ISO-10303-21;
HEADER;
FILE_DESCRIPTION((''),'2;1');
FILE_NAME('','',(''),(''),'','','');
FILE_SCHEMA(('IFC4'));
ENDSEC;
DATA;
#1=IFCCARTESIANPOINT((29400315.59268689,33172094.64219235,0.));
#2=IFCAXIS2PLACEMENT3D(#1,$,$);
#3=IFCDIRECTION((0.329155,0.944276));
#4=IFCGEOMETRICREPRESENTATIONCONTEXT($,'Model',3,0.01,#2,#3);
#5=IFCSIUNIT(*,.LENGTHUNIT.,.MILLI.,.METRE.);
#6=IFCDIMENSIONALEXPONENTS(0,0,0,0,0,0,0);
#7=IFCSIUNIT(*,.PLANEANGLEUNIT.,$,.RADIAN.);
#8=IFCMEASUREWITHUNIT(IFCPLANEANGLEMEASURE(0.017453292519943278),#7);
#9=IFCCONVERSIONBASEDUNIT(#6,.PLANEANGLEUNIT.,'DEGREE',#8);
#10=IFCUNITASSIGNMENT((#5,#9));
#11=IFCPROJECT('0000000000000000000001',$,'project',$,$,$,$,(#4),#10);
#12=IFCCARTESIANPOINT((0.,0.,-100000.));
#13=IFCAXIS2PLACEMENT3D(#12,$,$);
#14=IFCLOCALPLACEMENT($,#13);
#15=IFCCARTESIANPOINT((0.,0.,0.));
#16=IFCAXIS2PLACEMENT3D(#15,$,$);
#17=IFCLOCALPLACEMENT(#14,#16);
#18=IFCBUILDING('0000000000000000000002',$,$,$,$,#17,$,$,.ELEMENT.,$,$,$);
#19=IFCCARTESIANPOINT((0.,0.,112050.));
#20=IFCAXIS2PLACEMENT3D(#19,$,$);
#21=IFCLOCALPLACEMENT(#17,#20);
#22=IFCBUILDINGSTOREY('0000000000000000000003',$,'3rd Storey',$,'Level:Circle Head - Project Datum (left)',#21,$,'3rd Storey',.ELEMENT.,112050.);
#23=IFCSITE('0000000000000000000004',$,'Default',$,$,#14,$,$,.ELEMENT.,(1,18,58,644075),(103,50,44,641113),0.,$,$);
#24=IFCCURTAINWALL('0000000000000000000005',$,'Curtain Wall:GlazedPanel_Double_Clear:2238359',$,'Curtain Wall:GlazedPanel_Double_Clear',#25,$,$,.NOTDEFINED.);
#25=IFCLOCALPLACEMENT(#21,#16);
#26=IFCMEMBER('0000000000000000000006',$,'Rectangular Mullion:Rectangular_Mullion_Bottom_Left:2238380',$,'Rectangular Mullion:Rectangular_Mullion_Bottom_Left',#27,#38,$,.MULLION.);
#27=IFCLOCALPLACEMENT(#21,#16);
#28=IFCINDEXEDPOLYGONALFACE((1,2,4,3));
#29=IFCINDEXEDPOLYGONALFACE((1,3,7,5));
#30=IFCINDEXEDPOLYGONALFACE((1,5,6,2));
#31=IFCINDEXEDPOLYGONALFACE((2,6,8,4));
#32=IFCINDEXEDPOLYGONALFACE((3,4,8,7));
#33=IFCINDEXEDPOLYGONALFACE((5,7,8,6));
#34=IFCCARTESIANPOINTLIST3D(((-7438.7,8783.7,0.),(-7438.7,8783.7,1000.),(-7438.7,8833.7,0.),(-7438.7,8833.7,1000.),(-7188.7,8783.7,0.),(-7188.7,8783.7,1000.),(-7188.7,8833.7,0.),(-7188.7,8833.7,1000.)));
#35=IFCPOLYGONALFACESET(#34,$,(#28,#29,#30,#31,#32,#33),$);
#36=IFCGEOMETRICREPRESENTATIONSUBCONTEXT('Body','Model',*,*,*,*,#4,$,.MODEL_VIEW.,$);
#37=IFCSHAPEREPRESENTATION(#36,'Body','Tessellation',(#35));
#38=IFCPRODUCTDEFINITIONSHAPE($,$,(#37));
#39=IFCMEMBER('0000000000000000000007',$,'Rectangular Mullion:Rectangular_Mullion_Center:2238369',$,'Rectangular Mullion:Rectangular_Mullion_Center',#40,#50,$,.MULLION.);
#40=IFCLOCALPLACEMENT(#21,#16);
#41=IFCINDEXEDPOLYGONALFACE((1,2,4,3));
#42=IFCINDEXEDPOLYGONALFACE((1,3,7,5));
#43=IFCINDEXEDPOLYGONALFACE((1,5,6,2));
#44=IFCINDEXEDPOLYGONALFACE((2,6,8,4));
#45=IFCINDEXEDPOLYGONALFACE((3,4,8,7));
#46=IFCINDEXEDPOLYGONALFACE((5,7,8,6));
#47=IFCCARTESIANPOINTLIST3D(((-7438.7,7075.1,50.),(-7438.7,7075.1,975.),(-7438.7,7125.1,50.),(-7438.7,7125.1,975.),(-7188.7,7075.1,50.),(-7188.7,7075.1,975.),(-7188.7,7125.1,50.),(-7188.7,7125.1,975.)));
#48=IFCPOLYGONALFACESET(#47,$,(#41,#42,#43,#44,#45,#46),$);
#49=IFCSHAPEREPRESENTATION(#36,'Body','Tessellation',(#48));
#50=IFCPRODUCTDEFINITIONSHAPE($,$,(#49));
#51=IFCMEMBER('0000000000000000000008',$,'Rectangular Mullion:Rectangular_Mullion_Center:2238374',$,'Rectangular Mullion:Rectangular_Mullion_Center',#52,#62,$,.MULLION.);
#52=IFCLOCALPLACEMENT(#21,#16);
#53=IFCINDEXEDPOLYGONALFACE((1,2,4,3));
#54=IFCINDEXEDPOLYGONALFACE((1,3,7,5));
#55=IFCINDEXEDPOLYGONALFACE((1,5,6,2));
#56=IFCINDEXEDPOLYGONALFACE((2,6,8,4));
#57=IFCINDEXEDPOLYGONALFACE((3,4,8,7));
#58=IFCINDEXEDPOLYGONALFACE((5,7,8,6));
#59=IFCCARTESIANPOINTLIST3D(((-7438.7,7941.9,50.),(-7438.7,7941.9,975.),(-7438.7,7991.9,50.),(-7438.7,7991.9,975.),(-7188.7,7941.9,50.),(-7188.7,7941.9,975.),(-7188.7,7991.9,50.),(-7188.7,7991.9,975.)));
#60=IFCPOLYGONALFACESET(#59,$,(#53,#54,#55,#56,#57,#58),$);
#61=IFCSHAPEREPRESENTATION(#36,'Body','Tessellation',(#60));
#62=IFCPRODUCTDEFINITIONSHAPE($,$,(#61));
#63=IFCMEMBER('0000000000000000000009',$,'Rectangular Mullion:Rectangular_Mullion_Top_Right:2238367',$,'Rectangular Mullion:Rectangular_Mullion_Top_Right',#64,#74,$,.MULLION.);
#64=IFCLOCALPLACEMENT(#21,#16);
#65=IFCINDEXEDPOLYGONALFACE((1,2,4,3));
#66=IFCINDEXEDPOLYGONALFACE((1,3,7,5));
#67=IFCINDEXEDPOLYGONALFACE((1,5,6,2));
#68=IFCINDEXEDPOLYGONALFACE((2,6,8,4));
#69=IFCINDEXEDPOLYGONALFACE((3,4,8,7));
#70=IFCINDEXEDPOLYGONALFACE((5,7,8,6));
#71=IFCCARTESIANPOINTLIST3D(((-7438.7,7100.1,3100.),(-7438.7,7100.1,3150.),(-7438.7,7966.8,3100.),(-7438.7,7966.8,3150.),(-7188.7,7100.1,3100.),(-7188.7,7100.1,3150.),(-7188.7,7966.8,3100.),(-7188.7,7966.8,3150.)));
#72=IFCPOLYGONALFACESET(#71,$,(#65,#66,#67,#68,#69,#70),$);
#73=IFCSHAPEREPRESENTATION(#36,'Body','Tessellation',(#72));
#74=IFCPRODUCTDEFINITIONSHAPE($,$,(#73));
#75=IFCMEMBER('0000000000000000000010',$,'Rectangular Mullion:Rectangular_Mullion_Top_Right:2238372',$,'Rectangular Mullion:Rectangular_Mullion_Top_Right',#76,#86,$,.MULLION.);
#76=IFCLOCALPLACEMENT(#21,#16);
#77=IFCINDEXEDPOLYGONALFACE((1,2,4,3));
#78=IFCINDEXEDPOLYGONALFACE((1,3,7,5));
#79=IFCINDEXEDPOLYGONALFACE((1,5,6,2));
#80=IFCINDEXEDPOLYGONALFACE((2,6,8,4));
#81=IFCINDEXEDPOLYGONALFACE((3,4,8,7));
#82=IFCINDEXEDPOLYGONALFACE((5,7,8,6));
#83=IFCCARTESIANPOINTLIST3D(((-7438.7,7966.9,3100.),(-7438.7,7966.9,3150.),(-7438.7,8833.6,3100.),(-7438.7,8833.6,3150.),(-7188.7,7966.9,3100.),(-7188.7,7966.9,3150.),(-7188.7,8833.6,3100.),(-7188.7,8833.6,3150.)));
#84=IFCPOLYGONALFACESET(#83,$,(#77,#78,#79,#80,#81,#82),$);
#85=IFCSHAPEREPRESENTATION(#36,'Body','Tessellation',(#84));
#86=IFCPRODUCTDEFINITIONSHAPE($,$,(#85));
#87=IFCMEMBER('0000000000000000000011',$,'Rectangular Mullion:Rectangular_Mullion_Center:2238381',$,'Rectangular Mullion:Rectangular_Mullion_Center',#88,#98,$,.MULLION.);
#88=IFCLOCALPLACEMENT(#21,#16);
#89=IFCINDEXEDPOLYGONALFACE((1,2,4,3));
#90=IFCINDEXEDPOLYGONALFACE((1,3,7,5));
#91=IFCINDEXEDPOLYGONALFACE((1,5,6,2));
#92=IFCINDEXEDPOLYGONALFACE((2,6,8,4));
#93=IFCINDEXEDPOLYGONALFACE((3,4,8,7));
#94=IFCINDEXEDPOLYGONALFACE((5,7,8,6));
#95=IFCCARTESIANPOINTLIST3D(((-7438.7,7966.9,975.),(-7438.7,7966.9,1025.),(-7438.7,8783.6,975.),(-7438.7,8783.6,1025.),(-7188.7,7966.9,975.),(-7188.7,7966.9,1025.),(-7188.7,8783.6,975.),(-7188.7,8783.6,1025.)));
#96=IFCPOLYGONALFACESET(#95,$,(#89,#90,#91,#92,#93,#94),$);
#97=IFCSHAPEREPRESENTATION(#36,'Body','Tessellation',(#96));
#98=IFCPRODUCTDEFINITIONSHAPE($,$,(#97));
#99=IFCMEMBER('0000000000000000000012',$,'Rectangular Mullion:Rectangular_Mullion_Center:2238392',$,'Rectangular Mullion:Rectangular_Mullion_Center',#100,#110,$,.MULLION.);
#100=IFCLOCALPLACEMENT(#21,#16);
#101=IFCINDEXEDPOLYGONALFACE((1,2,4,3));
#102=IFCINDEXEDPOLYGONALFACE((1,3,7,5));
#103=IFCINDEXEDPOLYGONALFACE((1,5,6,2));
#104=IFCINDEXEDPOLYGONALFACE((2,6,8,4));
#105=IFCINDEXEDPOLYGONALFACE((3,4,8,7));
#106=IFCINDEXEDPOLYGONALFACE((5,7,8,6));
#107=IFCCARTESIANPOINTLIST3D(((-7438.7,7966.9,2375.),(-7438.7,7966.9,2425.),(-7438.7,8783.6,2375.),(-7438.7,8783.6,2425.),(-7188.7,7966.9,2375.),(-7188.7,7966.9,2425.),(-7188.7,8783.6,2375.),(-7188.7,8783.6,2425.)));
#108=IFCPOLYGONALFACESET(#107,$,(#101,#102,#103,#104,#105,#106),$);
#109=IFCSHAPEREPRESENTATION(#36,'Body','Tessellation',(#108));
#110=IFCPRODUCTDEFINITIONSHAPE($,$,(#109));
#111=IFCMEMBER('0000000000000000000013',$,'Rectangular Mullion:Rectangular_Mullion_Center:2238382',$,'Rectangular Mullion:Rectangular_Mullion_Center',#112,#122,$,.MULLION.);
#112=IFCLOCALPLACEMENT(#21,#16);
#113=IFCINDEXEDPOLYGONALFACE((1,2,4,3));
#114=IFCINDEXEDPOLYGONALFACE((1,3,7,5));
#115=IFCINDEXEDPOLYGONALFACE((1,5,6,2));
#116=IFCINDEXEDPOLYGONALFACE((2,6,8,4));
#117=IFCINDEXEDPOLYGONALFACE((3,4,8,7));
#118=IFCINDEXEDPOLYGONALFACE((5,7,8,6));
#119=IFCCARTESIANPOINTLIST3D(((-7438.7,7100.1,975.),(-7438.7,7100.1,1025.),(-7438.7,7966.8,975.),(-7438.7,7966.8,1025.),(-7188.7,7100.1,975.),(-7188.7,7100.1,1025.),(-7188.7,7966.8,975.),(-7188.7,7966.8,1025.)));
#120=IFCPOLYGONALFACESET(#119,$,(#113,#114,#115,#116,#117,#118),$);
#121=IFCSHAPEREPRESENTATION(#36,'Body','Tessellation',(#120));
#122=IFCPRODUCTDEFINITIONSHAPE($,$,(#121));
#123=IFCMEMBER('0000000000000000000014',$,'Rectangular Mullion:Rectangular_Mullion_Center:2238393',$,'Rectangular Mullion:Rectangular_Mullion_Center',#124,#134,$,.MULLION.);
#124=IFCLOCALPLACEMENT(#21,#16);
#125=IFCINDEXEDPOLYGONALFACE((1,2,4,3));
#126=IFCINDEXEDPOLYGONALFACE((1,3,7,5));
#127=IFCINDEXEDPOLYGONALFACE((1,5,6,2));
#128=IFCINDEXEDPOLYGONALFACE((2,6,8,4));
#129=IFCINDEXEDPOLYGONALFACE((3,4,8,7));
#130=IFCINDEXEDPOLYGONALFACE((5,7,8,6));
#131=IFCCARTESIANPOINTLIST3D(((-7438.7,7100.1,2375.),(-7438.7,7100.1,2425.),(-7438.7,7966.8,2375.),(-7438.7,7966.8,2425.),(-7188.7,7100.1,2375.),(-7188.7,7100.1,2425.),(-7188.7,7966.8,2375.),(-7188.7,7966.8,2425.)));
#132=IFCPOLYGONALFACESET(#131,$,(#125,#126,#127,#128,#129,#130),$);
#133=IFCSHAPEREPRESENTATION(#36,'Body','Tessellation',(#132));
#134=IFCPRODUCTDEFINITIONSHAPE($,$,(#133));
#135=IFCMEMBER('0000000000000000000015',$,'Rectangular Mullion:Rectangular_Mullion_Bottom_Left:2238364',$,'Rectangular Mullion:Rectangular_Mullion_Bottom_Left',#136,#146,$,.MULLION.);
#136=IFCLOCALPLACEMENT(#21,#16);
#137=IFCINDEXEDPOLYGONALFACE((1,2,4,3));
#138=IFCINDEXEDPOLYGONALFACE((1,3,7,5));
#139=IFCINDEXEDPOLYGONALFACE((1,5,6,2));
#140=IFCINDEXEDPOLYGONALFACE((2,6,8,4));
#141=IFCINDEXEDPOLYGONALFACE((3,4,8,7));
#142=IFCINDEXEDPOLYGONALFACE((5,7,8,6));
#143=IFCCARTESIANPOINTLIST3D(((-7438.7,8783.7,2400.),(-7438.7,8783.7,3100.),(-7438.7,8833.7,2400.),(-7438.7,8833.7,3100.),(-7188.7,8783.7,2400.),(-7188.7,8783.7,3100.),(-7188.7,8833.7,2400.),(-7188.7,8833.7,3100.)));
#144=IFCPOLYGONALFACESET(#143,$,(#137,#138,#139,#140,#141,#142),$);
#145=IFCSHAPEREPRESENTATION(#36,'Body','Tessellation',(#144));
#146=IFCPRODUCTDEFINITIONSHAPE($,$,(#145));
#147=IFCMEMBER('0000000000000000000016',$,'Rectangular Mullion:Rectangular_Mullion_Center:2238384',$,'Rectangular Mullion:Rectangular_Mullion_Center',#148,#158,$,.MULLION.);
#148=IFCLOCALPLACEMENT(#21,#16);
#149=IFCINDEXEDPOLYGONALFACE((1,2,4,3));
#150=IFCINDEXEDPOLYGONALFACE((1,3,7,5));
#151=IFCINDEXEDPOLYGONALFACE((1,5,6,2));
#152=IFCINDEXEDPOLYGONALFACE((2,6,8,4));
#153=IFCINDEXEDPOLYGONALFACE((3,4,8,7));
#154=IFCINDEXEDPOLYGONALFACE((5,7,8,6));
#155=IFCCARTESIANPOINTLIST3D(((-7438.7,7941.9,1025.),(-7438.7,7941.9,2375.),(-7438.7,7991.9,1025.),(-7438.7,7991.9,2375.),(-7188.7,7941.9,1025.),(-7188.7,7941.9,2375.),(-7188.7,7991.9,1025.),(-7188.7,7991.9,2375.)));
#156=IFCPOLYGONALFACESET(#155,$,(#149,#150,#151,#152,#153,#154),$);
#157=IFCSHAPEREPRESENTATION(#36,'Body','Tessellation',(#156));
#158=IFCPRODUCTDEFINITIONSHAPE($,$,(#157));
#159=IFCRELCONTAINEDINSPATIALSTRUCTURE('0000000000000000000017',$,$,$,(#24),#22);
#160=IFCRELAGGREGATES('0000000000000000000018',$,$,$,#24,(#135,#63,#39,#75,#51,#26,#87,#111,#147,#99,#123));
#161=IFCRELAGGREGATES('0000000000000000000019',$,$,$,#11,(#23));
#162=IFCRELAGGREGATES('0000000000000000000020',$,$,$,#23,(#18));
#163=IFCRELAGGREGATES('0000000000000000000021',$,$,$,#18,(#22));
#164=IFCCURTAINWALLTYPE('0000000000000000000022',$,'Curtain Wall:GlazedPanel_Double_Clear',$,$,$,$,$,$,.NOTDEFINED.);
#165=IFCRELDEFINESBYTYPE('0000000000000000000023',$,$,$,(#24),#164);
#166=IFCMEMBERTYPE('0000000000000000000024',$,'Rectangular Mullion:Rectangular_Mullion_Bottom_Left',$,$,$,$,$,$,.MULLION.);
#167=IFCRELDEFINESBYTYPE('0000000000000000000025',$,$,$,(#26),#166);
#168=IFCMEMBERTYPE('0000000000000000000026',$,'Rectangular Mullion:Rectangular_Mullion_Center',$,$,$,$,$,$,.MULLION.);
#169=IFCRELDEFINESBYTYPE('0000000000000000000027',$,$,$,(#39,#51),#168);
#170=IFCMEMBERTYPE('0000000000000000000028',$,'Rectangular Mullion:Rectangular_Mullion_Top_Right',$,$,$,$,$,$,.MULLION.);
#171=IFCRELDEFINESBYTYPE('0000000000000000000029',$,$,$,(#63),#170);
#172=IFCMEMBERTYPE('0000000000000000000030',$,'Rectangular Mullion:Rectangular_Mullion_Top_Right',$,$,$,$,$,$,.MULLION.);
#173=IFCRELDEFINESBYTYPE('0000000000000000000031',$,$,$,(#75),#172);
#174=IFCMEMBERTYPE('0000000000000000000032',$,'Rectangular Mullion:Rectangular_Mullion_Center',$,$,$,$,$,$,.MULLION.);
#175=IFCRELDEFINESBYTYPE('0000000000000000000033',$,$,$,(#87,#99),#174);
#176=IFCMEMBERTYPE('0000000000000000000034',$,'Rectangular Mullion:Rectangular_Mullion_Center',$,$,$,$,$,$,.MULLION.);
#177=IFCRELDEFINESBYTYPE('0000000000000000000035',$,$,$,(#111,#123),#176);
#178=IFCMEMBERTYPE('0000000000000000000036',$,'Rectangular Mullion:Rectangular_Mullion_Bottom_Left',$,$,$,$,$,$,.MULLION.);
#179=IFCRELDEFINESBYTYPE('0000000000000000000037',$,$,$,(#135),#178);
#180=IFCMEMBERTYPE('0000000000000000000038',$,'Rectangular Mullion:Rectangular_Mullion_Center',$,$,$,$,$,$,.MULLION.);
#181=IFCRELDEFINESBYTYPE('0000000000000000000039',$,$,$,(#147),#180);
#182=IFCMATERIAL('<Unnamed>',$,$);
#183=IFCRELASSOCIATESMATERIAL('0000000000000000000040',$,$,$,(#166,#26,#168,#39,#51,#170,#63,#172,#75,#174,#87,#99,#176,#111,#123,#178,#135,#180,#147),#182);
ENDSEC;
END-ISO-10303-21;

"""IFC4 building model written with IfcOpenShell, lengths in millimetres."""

from ifc_helpers import new_model, entity, si_unit, converted_unit, direction, frame, origin, place, context, subcontext, project, spatial, indexed_curve, outline, extrude, source, transform, mapped, material, type_object, type_shapes, element, aggregate, save


model = new_model("IFC4")

# Units and contexts
model_context = context("Model", 3, precision=0.01, world=frame((29400315.59268689, 33172094.64219235, 0.0)), true_north=direction((0.329155, 0.944276)))
body_context = subcontext(model_context, "Body", "Model", "MODEL_VIEW")
ifc_project = project(units=[si_unit("LENGTHUNIT", "METRE", prefix="MILLI"), converted_unit("PLANEANGLEUNIT", "DEGREE", entity("IfcPlaneAngleMeasure", 0.017453292519943278), si_unit("PLANEANGLEUNIT", "RADIAN"), dimensions=[0, 0, 0, 0, 0, 0, 0])], contexts=[model_context])

# Site, building, storey
site_placement = place(None, frame((0.0, 0.0, -100000.0)))
site = spatial("IfcSite", under=ifc_project, at=site_placement, Name="Default", CompositionType="ELEMENT", RefLatitude=(1, 18, 58, 644075), RefLongitude=(103, 50, 44, 641113), RefElevation=0.0)
building_placement = place(site_placement, origin())
building = spatial("IfcBuilding", under=site, at=building_placement, CompositionType="ELEMENT")
storey_placement = place(building_placement, frame((0.0, 0.0, 112050.0)))
storey = spatial("IfcBuildingStorey", under=building, at=storey_placement, Name="3rd Storey", ObjectType="Level:Circle Head - Project Datum (left)", LongName="3rd Storey", CompositionType="ELEMENT", Elevation=112050.0)

# Curtain wall, members
curtain_wall_type = type_object("IfcCurtainWallType", Name="Curtain Wall:GlazedPanel_Double_Clear", PredefinedType="NOTDEFINED")
curtain_wall_1_placement = place(storey_placement, frame((0.0, 0.0, -112050.0)))
curtain_wall_1 = element("IfcCurtainWall", 1, at=curtain_wall_1_placement, inside=storey, type_object=curtain_wall_type, Name="Curtain Wall:GlazedPanel_Double_Clear:2238359", ObjectType="Curtain Wall:GlazedPanel_Double_Clear", PredefinedType="NOTDEFINED")
ifc_material_1 = material(Name="<Unnamed>")
member_type_1 = type_object("IfcMemberType", Name="Rectangular Mullion:Rectangular_Mullion_Bottom_Left", PredefinedType="MULLION", material=ifc_material_1)
shared_shape_1 = source(origin(), body_context, "Body", "SweptSolid", [
    extrude(outline(indexed_curve([(-25.0, -125.0), (25.0, -125.0), (25.0, 125.0), (-25.0, 125.0), (-25.0, -125.0)], self_intersect=False)), frame((-25.0, 0.0, -1000.0), z_axis=(0.0, 0.0, 1.0), x_axis=(-1.0, 0.0, 0.0)), (0.0, 0.0, 1.0), 1000.0),
])
type_shapes(member_type_1, [shared_shape_1])
member_1_placement = place(curtain_wall_1_placement, frame((-7313.7, 8833.7, 113050.0), z_axis=(0.0, 0.0, 1.0), x_axis=(0.0, 1.0, 0.0)))
member_1 = element("IfcMember", 2, at=member_1_placement, type_object=member_type_1, material=ifc_material_1, Name="Rectangular Mullion:Rectangular_Mullion_Bottom_Left:2238380", ObjectType="Rectangular Mullion:Rectangular_Mullion_Bottom_Left", PredefinedType="MULLION", context=body_context, shape_type="MappedRepresentation", body=[
    mapped(shared_shape_1, transform((0.0, 0.0, 0.0), scale=1.0)),
])
member_type_2 = type_object("IfcMemberType", Name="Rectangular Mullion:Rectangular_Mullion_Center", PredefinedType="MULLION", material=ifc_material_1)
shared_shape_2 = source(origin(), body_context, "Body", "SweptSolid", [
    extrude(outline(indexed_curve([(-25.0, -125.0), (25.0, -125.0), (25.0, 125.0), (-25.0, 125.0), (-25.0, -125.0)], self_intersect=False)), frame((0.0, 0.0, -925.0), z_axis=(0.0, 0.0, 1.0), x_axis=(-1.0, 0.0, 0.0)), (0.0, 0.0, 1.0), 925.0),
])
type_shapes(member_type_2, [shared_shape_2])
member_2_placement = place(curtain_wall_1_placement, frame((-7313.7, 7100.1, 112100.0), z_axis=(0.0, 0.0, -1.0), x_axis=(0.0, -1.0, 0.0)))
member_2 = element("IfcMember", 3, at=member_2_placement, type_object=member_type_2, material=ifc_material_1, Name="Rectangular Mullion:Rectangular_Mullion_Center:2238369", ObjectType="Rectangular Mullion:Rectangular_Mullion_Center", PredefinedType="MULLION", context=body_context, shape_type="MappedRepresentation", body=[
    mapped(shared_shape_2, transform((0.0, 0.0, 0.0), scale=1.0)),
])
member_3_placement = place(curtain_wall_1_placement, frame((-7313.7, 7966.9, 112100.0), z_axis=(0.0, 0.0, -1.0), x_axis=(0.0, -1.0, 0.0)))
member_3 = element("IfcMember", 4, at=member_3_placement, type_object=member_type_2, material=ifc_material_1, Name="Rectangular Mullion:Rectangular_Mullion_Center:2238374", ObjectType="Rectangular Mullion:Rectangular_Mullion_Center", PredefinedType="MULLION", context=body_context, shape_type="MappedRepresentation", body=[
    mapped(shared_shape_2, transform((0.0, 0.0, 0.0), scale=1.0)),
])
member_type_3 = type_object("IfcMemberType", Name="Rectangular Mullion:Rectangular_Mullion_Top_Right", PredefinedType="MULLION", material=ifc_material_1)
shared_shape_3 = source(origin(), body_context, "Body", "SweptSolid", [
    extrude(outline(indexed_curve([(-25.0, -125.0), (25.0, -125.0), (25.0, 125.0), (-25.0, 125.0), (-25.0, -125.0)], self_intersect=False)), frame((-25.0, 0.0, -866.7), z_axis=(0.0, 0.0, 1.0), x_axis=(-1.0, 0.0, 0.0)), (0.0, 0.0, 1.0), 866.7),
])
type_shapes(member_type_3, [shared_shape_3])
member_4_placement = place(curtain_wall_1_placement, frame((-7313.7, 7100.1, 115200.0), z_axis=(0.0, -1.0, 0.0), x_axis=(0.0, 0.0, 1.0)))
member_4 = element("IfcMember", 5, at=member_4_placement, type_object=member_type_3, material=ifc_material_1, Name="Rectangular Mullion:Rectangular_Mullion_Top_Right:2238367", ObjectType="Rectangular Mullion:Rectangular_Mullion_Top_Right", PredefinedType="MULLION", context=body_context, shape_type="MappedRepresentation", body=[
    mapped(shared_shape_3, transform((0.0, 0.0, 0.0), scale=1.0)),
])
member_type_4 = type_object("IfcMemberType", Name="Rectangular Mullion:Rectangular_Mullion_Top_Right", PredefinedType="MULLION", material=ifc_material_1)
shared_shape_4 = source(origin(), body_context, "Body", "SweptSolid", [
    extrude(outline(indexed_curve([(-25.0, -125.0), (25.0, -125.0), (25.0, 125.0), (-25.0, 125.0), (-25.0, -125.0)], self_intersect=False)), frame((-25.0, 0.0, -866.7), z_axis=(0.0, 0.0, 1.0), x_axis=(-1.0, 0.0, 0.0)), (0.0, 0.0, 1.0), 866.7),
])
type_shapes(member_type_4, [shared_shape_4])
member_5_placement = place(curtain_wall_1_placement, frame((-7313.7, 7966.9, 115200.0), z_axis=(0.0, -1.0, 0.0), x_axis=(0.0, 0.0, 1.0)))
member_5 = element("IfcMember", 6, at=member_5_placement, type_object=member_type_4, material=ifc_material_1, Name="Rectangular Mullion:Rectangular_Mullion_Top_Right:2238372", ObjectType="Rectangular Mullion:Rectangular_Mullion_Top_Right", PredefinedType="MULLION", context=body_context, shape_type="MappedRepresentation", body=[
    mapped(shared_shape_4, transform((0.0, 0.0, 0.0), scale=1.0)),
])
member_type_5 = type_object("IfcMemberType", Name="Rectangular Mullion:Rectangular_Mullion_Center", PredefinedType="MULLION", material=ifc_material_1)
shared_shape_5 = source(origin(), body_context, "Body", "SweptSolid", [
    extrude(outline(indexed_curve([(-25.0, -125.0), (25.0, -125.0), (25.0, 125.0), (-25.0, 125.0), (-25.0, -125.0)], self_intersect=False)), frame((0.0, 0.0, -816.7), z_axis=(0.0, 0.0, 1.0), x_axis=(-1.0, 0.0, 0.0)), (0.0, 0.0, 1.0), 816.7),
])
type_shapes(member_type_5, [shared_shape_5])
member_6_placement = place(curtain_wall_1_placement, frame((-7313.7, 7966.9, 113050.0), z_axis=(0.0, -1.0, 0.0), x_axis=(0.0, 0.0, 1.0)))
member_6 = element("IfcMember", 7, at=member_6_placement, type_object=member_type_5, material=ifc_material_1, Name="Rectangular Mullion:Rectangular_Mullion_Center:2238381", ObjectType="Rectangular Mullion:Rectangular_Mullion_Center", PredefinedType="MULLION", context=body_context, shape_type="MappedRepresentation", body=[
    mapped(shared_shape_5, transform((0.0, 0.0, 0.0), scale=1.0)),
])
member_7_placement = place(curtain_wall_1_placement, frame((-7313.7, 7966.9, 114450.0), z_axis=(0.0, -1.0, 0.0), x_axis=(0.0, 0.0, 1.0)))
member_7 = element("IfcMember", 8, at=member_7_placement, type_object=member_type_5, material=ifc_material_1, Name="Rectangular Mullion:Rectangular_Mullion_Center:2238392", ObjectType="Rectangular Mullion:Rectangular_Mullion_Center", PredefinedType="MULLION", context=body_context, shape_type="MappedRepresentation", body=[
    mapped(shared_shape_5, transform((0.0, 0.0, 0.0), scale=1.0)),
])
member_type_6 = type_object("IfcMemberType", Name="Rectangular Mullion:Rectangular_Mullion_Center", PredefinedType="MULLION", material=ifc_material_1)
shared_shape_6 = source(origin(), body_context, "Body", "SweptSolid", [
    extrude(outline(indexed_curve([(-25.0, -125.0), (25.0, -125.0), (25.0, 125.0), (-25.0, 125.0), (-25.0, -125.0)], self_intersect=False)), frame((0.0, 0.0, -866.7), z_axis=(0.0, 0.0, 1.0), x_axis=(-1.0, 0.0, 0.0)), (0.0, 0.0, 1.0), 866.7),
])
type_shapes(member_type_6, [shared_shape_6])
member_8_placement = place(curtain_wall_1_placement, frame((-7313.7, 7100.1, 113050.0), z_axis=(0.0, -1.0, 0.0), x_axis=(0.0, 0.0, 1.0)))
member_8 = element("IfcMember", 9, at=member_8_placement, type_object=member_type_6, material=ifc_material_1, Name="Rectangular Mullion:Rectangular_Mullion_Center:2238382", ObjectType="Rectangular Mullion:Rectangular_Mullion_Center", PredefinedType="MULLION", context=body_context, shape_type="MappedRepresentation", body=[
    mapped(shared_shape_6, transform((0.0, 0.0, 0.0), scale=1.0)),
])
member_9_placement = place(curtain_wall_1_placement, frame((-7313.7, 7100.1, 114450.0), z_axis=(0.0, -1.0, 0.0), x_axis=(0.0, 0.0, 1.0)))
member_9 = element("IfcMember", 10, at=member_9_placement, type_object=member_type_6, material=ifc_material_1, Name="Rectangular Mullion:Rectangular_Mullion_Center:2238393", ObjectType="Rectangular Mullion:Rectangular_Mullion_Center", PredefinedType="MULLION", context=body_context, shape_type="MappedRepresentation", body=[
    mapped(shared_shape_6, transform((0.0, 0.0, 0.0), scale=1.0)),
])
member_type_7 = type_object("IfcMemberType", Name="Rectangular Mullion:Rectangular_Mullion_Bottom_Left", PredefinedType="MULLION", material=ifc_material_1)
shared_shape_7 = source(origin(), body_context, "Body", "SweptSolid", [
    extrude(outline(indexed_curve([(-25.0, -125.0), (25.0, -125.0), (25.0, 125.0), (-25.0, 125.0), (-25.0, -125.0)], self_intersect=False)), frame((-25.0, 0.0, -700.0), z_axis=(0.0, 0.0, 1.0), x_axis=(-1.0, 0.0, 0.0)), (0.0, 0.0, 1.0), 700.0),
])
type_shapes(member_type_7, [shared_shape_7])
member_10_placement = place(curtain_wall_1_placement, frame((-7313.7, 8833.7, 115150.0), z_axis=(0.0, 0.0, 1.0), x_axis=(0.0, 1.0, 0.0)))
member_10 = element("IfcMember", 11, at=member_10_placement, type_object=member_type_7, material=ifc_material_1, Name="Rectangular Mullion:Rectangular_Mullion_Bottom_Left:2238364", ObjectType="Rectangular Mullion:Rectangular_Mullion_Bottom_Left", PredefinedType="MULLION", context=body_context, shape_type="MappedRepresentation", body=[
    mapped(shared_shape_7, transform((0.0, 0.0, 0.0), scale=1.0)),
])
member_type_8 = type_object("IfcMemberType", Name="Rectangular Mullion:Rectangular_Mullion_Center", PredefinedType="MULLION", material=ifc_material_1)
shared_shape_8 = source(origin(), body_context, "Body", "SweptSolid", [
    extrude(outline(indexed_curve([(-25.0, -125.0), (25.0, -125.0), (25.0, 125.0), (-25.0, 125.0), (-25.0, -125.0)], self_intersect=False)), frame((0.0, 0.0, -1350.0), z_axis=(0.0, 0.0, 1.0), x_axis=(-1.0, 0.0, 0.0)), (0.0, 0.0, 1.0), 1350.0),
])
type_shapes(member_type_8, [shared_shape_8])
member_11_placement = place(curtain_wall_1_placement, frame((-7313.7, 7966.9, 113075.0), z_axis=(0.0, 0.0, -1.0), x_axis=(0.0, -1.0, 0.0)))
member_11 = element("IfcMember", 12, at=member_11_placement, type_object=member_type_8, material=ifc_material_1, Name="Rectangular Mullion:Rectangular_Mullion_Center:2238384", ObjectType="Rectangular Mullion:Rectangular_Mullion_Center", PredefinedType="MULLION", context=body_context, shape_type="MappedRepresentation", body=[
    mapped(shared_shape_8, transform((0.0, 0.0, 0.0), scale=1.0)),
])

aggregate(curtain_wall_1, [member_10, member_4, member_2, member_5, member_3, member_1, member_6, member_8, member_11, member_7, member_9])

save(model, "model.ifc")
